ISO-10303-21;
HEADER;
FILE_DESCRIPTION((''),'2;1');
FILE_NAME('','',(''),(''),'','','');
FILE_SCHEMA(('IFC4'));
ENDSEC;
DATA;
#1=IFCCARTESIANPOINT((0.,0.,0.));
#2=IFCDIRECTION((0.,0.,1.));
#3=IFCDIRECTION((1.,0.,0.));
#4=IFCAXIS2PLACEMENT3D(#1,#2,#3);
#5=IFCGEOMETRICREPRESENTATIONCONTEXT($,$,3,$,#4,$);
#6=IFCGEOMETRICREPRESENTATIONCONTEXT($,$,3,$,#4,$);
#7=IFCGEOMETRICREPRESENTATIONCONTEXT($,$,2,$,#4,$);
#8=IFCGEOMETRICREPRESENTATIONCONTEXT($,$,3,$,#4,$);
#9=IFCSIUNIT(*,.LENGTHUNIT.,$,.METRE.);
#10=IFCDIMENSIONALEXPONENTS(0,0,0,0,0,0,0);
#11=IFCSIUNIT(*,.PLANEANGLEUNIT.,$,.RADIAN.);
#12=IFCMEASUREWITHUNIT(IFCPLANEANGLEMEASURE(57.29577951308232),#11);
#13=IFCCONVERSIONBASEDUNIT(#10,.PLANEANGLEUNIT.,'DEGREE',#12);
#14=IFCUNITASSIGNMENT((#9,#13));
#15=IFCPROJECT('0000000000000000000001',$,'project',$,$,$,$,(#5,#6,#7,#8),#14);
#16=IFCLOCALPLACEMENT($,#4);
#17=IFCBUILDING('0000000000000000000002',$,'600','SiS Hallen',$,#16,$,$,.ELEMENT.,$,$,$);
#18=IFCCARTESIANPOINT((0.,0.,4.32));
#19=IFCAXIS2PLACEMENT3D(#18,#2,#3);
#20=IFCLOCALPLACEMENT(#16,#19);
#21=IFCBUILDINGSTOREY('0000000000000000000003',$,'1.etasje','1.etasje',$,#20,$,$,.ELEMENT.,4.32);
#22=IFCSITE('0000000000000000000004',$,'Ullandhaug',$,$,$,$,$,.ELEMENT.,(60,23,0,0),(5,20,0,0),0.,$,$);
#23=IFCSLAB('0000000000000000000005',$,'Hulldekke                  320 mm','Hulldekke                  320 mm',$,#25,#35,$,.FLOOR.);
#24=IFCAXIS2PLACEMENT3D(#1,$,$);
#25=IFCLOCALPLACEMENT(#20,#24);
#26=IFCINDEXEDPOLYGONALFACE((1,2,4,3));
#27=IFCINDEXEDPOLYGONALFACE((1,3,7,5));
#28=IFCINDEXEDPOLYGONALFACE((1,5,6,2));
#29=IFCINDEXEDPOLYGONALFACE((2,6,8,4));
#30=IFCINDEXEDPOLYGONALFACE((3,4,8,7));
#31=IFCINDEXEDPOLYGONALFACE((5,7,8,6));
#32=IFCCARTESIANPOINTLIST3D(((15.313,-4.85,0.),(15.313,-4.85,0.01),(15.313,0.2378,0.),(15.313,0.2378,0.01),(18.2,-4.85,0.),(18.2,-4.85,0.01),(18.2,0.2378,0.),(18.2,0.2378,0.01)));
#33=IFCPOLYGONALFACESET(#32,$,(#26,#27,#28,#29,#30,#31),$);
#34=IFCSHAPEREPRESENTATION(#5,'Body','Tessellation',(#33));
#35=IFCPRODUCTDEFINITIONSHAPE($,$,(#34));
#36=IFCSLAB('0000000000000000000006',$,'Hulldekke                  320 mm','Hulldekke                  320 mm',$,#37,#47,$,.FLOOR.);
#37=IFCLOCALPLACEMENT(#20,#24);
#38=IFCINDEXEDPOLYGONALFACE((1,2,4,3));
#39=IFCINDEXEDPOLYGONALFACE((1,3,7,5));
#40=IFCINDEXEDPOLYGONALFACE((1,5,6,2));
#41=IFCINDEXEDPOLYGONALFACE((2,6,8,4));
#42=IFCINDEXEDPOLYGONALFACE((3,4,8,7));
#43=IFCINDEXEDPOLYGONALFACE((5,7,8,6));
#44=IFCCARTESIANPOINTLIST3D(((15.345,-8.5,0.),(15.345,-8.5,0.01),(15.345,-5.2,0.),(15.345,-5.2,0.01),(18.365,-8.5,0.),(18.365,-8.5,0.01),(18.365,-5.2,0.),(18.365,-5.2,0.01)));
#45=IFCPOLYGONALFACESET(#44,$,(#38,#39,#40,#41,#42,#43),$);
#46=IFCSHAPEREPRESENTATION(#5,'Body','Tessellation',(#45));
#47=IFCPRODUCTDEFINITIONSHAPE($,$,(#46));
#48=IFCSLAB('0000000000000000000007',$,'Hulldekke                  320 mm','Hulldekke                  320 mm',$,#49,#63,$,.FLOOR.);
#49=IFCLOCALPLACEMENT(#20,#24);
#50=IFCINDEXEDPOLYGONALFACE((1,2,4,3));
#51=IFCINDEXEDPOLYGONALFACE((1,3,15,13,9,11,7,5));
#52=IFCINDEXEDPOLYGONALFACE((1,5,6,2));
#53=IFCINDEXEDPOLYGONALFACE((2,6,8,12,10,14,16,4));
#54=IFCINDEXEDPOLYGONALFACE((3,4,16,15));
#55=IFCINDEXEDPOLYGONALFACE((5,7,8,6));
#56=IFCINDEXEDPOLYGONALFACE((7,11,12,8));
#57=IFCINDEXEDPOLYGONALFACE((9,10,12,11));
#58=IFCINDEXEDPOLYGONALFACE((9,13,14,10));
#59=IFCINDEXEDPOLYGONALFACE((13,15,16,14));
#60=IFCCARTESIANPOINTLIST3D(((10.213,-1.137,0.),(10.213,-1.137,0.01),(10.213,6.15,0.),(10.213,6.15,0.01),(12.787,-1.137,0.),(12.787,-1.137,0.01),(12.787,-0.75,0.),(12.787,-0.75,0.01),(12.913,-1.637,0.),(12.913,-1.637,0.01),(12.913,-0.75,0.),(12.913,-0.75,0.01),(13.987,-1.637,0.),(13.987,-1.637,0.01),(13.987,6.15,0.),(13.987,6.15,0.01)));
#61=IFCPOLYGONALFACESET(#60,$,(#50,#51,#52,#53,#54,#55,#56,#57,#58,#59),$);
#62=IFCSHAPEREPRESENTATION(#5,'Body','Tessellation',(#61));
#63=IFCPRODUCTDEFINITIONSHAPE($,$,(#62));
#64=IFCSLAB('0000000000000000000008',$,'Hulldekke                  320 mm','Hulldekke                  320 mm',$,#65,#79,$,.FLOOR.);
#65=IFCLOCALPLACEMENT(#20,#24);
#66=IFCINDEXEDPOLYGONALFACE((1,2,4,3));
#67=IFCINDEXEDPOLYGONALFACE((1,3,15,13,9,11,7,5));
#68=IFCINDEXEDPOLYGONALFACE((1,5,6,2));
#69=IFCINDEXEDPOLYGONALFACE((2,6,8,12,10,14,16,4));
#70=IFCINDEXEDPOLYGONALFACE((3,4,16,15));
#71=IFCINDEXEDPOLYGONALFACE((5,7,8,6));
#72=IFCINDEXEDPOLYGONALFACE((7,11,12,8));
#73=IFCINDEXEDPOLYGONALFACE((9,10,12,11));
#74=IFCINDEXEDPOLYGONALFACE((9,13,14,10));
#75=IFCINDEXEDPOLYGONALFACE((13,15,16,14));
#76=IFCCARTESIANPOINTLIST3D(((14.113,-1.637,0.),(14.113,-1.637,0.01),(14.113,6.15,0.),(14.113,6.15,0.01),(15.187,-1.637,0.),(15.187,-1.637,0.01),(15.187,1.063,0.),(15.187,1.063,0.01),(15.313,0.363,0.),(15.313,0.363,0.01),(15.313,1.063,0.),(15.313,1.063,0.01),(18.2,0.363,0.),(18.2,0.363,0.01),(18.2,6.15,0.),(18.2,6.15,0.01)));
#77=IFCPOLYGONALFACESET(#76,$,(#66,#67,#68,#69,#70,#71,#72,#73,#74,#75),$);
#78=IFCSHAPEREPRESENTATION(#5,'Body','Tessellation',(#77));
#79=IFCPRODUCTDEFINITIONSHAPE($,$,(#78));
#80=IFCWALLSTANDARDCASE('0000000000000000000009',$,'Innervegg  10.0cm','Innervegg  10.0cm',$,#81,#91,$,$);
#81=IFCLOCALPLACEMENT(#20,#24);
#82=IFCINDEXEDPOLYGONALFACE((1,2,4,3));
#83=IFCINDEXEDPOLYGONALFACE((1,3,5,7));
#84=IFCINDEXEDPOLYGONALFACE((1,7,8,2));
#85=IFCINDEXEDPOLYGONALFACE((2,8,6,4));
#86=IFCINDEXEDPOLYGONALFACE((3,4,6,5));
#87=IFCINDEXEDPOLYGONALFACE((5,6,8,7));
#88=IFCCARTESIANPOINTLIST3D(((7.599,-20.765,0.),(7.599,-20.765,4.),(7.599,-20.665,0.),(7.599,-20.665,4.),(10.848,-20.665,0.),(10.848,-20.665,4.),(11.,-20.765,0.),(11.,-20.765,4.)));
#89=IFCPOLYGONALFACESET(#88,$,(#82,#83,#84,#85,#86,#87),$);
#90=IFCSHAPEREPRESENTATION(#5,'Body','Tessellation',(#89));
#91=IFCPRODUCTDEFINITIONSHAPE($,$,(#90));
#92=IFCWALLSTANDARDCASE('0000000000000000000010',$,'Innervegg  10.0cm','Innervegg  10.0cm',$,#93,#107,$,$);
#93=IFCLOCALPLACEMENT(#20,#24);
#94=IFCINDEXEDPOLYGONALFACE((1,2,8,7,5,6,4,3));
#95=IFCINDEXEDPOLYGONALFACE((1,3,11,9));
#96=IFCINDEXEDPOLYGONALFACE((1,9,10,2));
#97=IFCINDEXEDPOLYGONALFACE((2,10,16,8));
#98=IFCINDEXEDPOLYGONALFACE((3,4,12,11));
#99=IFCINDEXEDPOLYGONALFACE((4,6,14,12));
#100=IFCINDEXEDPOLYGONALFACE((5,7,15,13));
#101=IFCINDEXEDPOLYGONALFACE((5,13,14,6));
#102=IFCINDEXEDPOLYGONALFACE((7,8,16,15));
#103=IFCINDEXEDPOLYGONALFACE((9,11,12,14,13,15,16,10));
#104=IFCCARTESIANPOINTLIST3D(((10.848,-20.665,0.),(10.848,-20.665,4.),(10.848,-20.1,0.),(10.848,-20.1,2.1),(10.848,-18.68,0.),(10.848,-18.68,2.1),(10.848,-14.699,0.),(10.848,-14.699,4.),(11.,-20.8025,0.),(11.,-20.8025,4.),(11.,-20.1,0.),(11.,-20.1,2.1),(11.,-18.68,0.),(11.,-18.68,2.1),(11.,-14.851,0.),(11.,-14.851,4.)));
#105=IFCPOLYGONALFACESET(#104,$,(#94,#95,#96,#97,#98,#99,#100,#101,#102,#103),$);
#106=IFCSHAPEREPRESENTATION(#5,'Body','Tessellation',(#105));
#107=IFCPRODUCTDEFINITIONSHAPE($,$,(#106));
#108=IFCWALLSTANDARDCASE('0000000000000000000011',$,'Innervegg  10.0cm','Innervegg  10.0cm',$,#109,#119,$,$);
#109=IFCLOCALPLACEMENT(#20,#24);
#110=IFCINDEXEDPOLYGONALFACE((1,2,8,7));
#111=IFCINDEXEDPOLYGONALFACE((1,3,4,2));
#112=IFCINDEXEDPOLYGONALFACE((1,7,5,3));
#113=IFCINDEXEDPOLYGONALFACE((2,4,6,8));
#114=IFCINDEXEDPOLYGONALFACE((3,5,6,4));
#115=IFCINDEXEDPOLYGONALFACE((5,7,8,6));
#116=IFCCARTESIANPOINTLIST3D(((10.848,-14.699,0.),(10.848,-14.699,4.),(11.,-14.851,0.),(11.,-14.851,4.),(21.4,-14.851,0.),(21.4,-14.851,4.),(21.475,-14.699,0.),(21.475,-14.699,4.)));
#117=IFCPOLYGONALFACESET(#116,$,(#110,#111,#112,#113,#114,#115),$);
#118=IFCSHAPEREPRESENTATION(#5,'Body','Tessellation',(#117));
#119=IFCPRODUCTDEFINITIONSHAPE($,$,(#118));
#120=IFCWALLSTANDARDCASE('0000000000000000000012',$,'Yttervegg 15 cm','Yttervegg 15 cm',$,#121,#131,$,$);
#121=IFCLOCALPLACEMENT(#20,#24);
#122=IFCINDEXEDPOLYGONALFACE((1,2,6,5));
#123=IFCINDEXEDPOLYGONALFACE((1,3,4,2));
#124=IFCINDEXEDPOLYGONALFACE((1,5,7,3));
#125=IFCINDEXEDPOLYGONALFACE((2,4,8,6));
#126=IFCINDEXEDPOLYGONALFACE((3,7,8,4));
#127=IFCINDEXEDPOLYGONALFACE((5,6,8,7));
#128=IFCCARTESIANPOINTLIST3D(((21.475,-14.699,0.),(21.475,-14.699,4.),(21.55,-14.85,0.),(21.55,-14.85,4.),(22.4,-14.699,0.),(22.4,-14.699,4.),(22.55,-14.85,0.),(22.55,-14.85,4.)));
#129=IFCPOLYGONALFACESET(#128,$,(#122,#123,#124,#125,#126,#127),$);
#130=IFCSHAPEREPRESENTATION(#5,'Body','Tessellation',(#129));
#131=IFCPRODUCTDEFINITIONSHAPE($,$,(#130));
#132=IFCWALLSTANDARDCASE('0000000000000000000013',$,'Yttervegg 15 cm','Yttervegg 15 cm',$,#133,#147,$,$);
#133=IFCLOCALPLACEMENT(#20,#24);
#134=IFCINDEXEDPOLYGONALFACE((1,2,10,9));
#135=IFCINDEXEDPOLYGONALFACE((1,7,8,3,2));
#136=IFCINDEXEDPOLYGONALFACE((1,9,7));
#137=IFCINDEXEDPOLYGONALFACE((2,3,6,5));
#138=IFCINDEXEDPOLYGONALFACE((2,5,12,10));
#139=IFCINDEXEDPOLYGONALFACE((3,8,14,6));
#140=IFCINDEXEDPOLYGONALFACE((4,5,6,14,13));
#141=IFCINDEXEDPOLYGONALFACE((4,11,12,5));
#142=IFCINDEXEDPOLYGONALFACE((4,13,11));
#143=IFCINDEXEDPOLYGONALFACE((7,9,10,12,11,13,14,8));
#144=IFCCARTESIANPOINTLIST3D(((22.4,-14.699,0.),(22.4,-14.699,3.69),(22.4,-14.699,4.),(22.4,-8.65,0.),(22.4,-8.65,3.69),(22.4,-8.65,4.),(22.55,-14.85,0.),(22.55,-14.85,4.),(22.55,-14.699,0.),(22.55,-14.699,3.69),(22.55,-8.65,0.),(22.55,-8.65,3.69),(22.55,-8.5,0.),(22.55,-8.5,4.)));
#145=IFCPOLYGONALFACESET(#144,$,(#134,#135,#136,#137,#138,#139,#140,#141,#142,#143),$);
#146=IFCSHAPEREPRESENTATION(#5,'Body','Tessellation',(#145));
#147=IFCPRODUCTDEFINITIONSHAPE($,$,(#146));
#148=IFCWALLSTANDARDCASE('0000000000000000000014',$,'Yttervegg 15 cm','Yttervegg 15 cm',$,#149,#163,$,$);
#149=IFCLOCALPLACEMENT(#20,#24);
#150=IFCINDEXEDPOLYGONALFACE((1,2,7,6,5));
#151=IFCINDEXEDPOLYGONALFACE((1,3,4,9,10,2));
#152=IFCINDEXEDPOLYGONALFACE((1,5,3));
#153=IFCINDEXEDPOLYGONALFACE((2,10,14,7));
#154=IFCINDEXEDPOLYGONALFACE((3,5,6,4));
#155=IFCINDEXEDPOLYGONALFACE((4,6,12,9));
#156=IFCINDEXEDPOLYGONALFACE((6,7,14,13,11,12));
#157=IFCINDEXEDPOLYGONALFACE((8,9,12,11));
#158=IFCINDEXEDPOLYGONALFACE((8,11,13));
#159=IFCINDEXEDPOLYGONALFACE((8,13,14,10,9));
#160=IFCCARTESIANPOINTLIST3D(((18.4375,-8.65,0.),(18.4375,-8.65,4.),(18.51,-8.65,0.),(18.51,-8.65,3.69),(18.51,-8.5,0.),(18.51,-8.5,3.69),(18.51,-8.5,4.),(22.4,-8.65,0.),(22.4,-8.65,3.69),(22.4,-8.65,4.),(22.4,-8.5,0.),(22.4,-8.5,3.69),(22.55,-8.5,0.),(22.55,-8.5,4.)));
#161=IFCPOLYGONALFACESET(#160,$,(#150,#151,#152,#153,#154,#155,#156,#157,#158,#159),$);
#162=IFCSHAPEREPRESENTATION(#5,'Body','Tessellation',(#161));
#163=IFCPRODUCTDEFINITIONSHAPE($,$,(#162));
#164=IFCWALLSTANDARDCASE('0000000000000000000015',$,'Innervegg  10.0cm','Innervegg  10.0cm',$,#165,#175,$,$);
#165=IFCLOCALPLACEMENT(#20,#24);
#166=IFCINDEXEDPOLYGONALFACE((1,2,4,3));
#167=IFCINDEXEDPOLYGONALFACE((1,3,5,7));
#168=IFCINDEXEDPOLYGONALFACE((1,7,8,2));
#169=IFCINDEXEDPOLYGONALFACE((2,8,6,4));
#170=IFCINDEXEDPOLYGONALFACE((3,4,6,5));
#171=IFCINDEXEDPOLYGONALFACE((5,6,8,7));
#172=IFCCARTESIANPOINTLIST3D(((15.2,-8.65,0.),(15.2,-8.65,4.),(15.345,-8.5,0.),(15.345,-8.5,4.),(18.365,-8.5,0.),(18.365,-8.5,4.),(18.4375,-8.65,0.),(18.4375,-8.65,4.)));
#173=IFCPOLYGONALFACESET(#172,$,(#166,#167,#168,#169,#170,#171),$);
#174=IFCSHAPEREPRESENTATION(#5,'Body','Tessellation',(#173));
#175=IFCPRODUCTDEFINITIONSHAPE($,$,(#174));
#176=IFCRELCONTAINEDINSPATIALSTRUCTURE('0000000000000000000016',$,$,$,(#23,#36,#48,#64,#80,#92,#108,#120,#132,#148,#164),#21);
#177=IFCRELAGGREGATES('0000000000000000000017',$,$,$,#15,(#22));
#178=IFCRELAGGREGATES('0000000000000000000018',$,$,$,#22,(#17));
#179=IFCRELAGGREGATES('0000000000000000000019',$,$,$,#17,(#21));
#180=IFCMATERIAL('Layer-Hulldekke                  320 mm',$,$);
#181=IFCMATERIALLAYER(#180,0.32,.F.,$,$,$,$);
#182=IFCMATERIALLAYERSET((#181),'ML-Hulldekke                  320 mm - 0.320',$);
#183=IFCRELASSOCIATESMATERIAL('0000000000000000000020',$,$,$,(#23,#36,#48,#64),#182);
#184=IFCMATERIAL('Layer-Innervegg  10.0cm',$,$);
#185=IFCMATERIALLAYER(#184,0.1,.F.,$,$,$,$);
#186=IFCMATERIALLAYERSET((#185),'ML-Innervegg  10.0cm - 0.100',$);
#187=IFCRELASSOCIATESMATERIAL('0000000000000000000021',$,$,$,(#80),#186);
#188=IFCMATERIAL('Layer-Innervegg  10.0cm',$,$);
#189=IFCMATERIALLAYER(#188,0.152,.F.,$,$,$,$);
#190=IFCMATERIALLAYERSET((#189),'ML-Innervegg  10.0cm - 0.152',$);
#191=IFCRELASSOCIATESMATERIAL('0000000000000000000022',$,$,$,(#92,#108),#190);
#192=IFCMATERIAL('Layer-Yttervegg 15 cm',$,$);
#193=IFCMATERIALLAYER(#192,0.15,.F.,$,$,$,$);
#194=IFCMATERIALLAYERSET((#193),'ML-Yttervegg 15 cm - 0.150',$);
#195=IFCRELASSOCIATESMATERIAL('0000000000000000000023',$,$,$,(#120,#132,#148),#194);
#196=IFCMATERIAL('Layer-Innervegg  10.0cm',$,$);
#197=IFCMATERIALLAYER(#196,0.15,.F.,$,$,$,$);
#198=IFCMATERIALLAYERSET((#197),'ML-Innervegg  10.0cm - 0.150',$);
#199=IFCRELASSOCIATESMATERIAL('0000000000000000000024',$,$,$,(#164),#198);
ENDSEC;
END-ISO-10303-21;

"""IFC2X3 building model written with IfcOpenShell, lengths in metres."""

from ifc_helpers import new_model, entity, si_unit, converted_unit, frame, origin_with_axes, place, context, project, spatial, polyline, outline, extrude, material, layer, layer_set, layer_usage, element, save


model = new_model("IFC2X3")

# Units and contexts
context_of_model_1 = context(None, 3, world=origin_with_axes())
context_of_model_2 = context(None, 3, world=origin_with_axes())
context_of_model_3 = context(None, 2, world=origin_with_axes())
context_of_model_4 = context(None, 3, world=origin_with_axes())
ifc_project = project(units=[si_unit("LENGTHUNIT", "METRE"), converted_unit("PLANEANGLEUNIT", "DEGREE", entity("IfcPlaneAngleMeasure", 57.29577951308232), si_unit("PLANEANGLEUNIT", "RADIAN"), dimensions=[0, 0, 0, 0, 0, 0, 0])], contexts=[context_of_model_1, context_of_model_2, context_of_model_3, context_of_model_4])

# Site, building, storey
site = spatial("IfcSite", under=ifc_project, Name="Ullandhaug", CompositionType="ELEMENT", RefLatitude=(60, 23, 0, 0), RefLongitude=(5, 20, 0, 0), RefElevation=0.0)
building_placement = place(None, origin_with_axes())
building = spatial("IfcBuilding", under=site, at=building_placement, Name="600", Description="SiS Hallen", CompositionType="ELEMENT")
storey_placement = place(building_placement, frame((0.0, 0.0, 4.32), z_axis=(0.0, 0.0, 1.0), x_axis=(1.0, 0.0, 0.0)))
storey = spatial("IfcBuildingStorey", under=building, at=storey_placement, Name="1.etasje", Description="1.etasje", CompositionType="ELEMENT", Elevation=4.32)

# Slabs
ifc_material_1 = material(Name="Layer-Hulldekke                  320 mm")
ifc_layer_1 = layer(ifc_material_1, 0.32, ventilated=False)
ifc_layer_set_1 = layer_set([ifc_layer_1], Name="ML-Hulldekke                  320 mm - 0.320")
ifc_layer_usage_1 = layer_usage(ifc_layer_set_1, "AXIS2", "POSITIVE", 0.0)
slab_1_placement = place(storey_placement, frame((15.313, -4.85, 0.0), z_axis=(0.0, 0.0, 1.0), x_axis=(1.0, 0.0, 0.0)))
element("IfcSlab", 1, at=slab_1_placement, inside=storey, material=ifc_layer_usage_1, Name="Hulldekke                  320 mm", Description="Hulldekke                  320 mm", PredefinedType="FLOOR", context=context_of_model_1, shape_type="SweptSolid", body=[
    extrude(outline(polyline([(0.0, 0.0), (2.887, 0.0), (2.887, 5.0878), (0.0, 5.0878), (0.0, 0.0)])), origin_with_axes(), (0.0, 0.0, 1.0), 0.01),
])
slab_2_placement = place(storey_placement, frame((15.345, -8.5, 0.0), z_axis=(0.0, 0.0, 1.0), x_axis=(1.0, 0.0, 0.0)))
element("IfcSlab", 2, at=slab_2_placement, inside=storey, material=ifc_layer_usage_1, Name="Hulldekke                  320 mm", Description="Hulldekke                  320 mm", PredefinedType="FLOOR", context=context_of_model_1, shape_type="SweptSolid", body=[
    extrude(outline(polyline([(0.0, 0.0), (3.02, 0.0), (3.02, 3.3), (0.0, 3.3), (0.0, 0.0)])), origin_with_axes(), (0.0, 0.0, 1.0), 0.01),
])
slab_3_placement = place(storey_placement, frame((12.913, -1.637, 0.0), z_axis=(0.0, 0.0, 1.0), x_axis=(1.0, 0.0, 0.0)))
element("IfcSlab", 3, at=slab_3_placement, inside=storey, material=ifc_layer_usage_1, Name="Hulldekke                  320 mm", Description="Hulldekke                  320 mm", PredefinedType="FLOOR", context=context_of_model_1, shape_type="SweptSolid", body=[
    extrude(outline(polyline([(0.0, 0.0), (1.074, 0.0), (1.074, 7.787), (-2.7, 7.787), (-2.7, 0.5), (-0.126, 0.5), (-0.126, 0.887), (0.0, 0.887), (0.0, 0.0)])), origin_with_axes(), (0.0, 0.0, 1.0), 0.01),
])
slab_4_placement = place(storey_placement, frame((14.113, -1.637, 0.0), z_axis=(0.0, 0.0, 1.0), x_axis=(1.0, 0.0, 0.0)))
element("IfcSlab", 4, at=slab_4_placement, inside=storey, material=ifc_layer_usage_1, Name="Hulldekke                  320 mm", Description="Hulldekke                  320 mm", PredefinedType="FLOOR", context=context_of_model_1, shape_type="SweptSolid", body=[
    extrude(outline(polyline([(0.0, 0.0), (1.074, 0.0), (1.074, 2.7), (1.2, 2.7), (1.2, 2.0), (4.087, 2.0), (4.087, 7.787), (0.0, 7.787), (0.0, 0.0)])), origin_with_axes(), (0.0, 0.0, 1.0), 0.01),
])

# Wall
ifc_material_2 = material(Name="Layer-Yttervegg 15 cm")
ifc_layer_2 = layer(ifc_material_2, 0.15, ventilated=False)
ifc_layer_set_2 = layer_set([ifc_layer_2], Name="ML-Yttervegg 15 cm - 0.150")
ifc_layer_usage_2 = layer_usage(ifc_layer_set_2, "AXIS2", "POSITIVE", 0.0)
ifc_material_3 = material(Name="Layer-Innervegg  10.0cm")
ifc_layer_3 = layer(ifc_material_3, 0.1, ventilated=False)
ifc_layer_set_3 = layer_set([ifc_layer_3], Name="ML-Innervegg  10.0cm - 0.100")
ifc_layer_usage_3 = layer_usage(ifc_layer_set_3, "AXIS2", "POSITIVE", 0.0)
wall_1_placement = place(storey_placement, frame((7.599, -20.765, 0.0), z_axis=(0.0, 0.0, 1.0), x_axis=(1.0, 0.0, 0.0)))
element("IfcWallStandardCase", 5, at=wall_1_placement, inside=storey, material=ifc_layer_usage_3, Name="Innervegg  10.0cm", Description="Innervegg  10.0cm", context=context_of_model_1, shape_type="SweptSolid", body=[
    extrude(outline(polyline([(0.0, 0.0), (3.401, 0.0), (3.249, 0.1), (0.0, 0.1), (0.0, 0.0)])), origin_with_axes(), (0.0, 0.0, 1.0), 4.0),
])

# Wall, opening
ifc_material_4 = material(Name="Layer-Innervegg  10.0cm")
ifc_layer_4 = layer(ifc_material_4, 0.152, ventilated=False)
ifc_layer_set_4 = layer_set([ifc_layer_4], Name="ML-Innervegg  10.0cm - 0.152")
ifc_layer_usage_4 = layer_usage(ifc_layer_set_4, "AXIS2", "POSITIVE", 0.0)
wall_2_placement = place(storey_placement, frame((11.0, -20.8025, 0.0), z_axis=(0.0, 0.0, 1.0), x_axis=(0.0, 1.0, 0.0)))
wall_2 = element("IfcWallStandardCase", 6, at=wall_2_placement, inside=storey, material=ifc_layer_usage_4, Name="Innervegg  10.0cm", Description="Innervegg  10.0cm", context=context_of_model_1, shape_type="SweptSolid", body=[
    extrude(outline(polyline([(0.0, 0.0), (5.9515, 0.0), (6.1035, 0.152), (0.1375, 0.152), (0.0, 0.0)])), frame((0.0, 0.0, 0.0), z_axis=(0.0, 0.0, 1.0), x_axis=(1.0, 0.0, 0.0)), (0.0, 0.0, 1.0), 4.0),
])
opening_1_placement = place(wall_2_placement, frame((0.7025, 0.152, 0.0), z_axis=(0.0, 0.0, 1.0), x_axis=(1.0, 0.0, 0.0)))
element("IfcOpeningElement", 7, at=opening_1_placement, cuts=wall_2, context=context_of_model_1, shape_type="SweptSolid", body=[
    extrude(outline(polyline([(0.0, 0.0), (2.1, 0.0), (2.1, 1.42), (0.0, 1.42), (0.0, 0.0)])), frame((0.0, 0.0, 0.0), z_axis=(0.0, 1.0, 0.0), x_axis=(0.0, 0.0, 1.0)), (0.0, 0.0, -1.0), 0.152),
])

# Walls
wall_3_placement = place(storey_placement, frame((11.0, -14.851, 0.0), z_axis=(0.0, 0.0, 1.0), x_axis=(1.0, 0.0, 0.0)))
element("IfcWallStandardCase", 8, at=wall_3_placement, inside=storey, material=ifc_layer_usage_4, Name="Innervegg  10.0cm", Description="Innervegg  10.0cm", context=context_of_model_1, shape_type="SweptSolid", body=[
    extrude(outline(polyline([(0.0, 0.0), (10.4, 0.0), (10.475, 0.152), (-0.152, 0.152), (0.0, 0.0)])), origin_with_axes(), (0.0, 0.0, 1.0), 4.0),
])
wall_4_placement = place(storey_placement, frame((21.55, -14.85, 0.0), z_axis=(0.0, 0.0, 1.0), x_axis=(1.0, 0.0, 0.0)))
element("IfcWallStandardCase", 9, at=wall_4_placement, inside=storey, material=ifc_layer_usage_2, Name="Yttervegg 15 cm", Description="Yttervegg 15 cm", context=context_of_model_1, shape_type="SweptSolid", body=[
    extrude(outline(polyline([(0.0, 0.0), (1.0, 0.0), (0.85, 0.151), (-0.075, 0.151), (0.0, 0.0)])), origin_with_axes(), (0.0, 0.0, 1.0), 4.0),
])

# Walls, openings
wall_5_placement = place(storey_placement, frame((22.55, -14.85, 0.0), z_axis=(0.0, 0.0, 1.0), x_axis=(0.0, 1.0, 0.0)))
wall_5 = element("IfcWallStandardCase", 10, at=wall_5_placement, inside=storey, material=ifc_layer_usage_2, Name="Yttervegg 15 cm", Description="Yttervegg 15 cm", context=context_of_model_1, shape_type="SweptSolid", body=[
    extrude(outline(polyline([(0.0, 0.0), (6.35, 0.0), (6.2, 0.15), (0.151, 0.15), (0.0, 0.0)])), frame((0.0, 0.0, 0.0), z_axis=(0.0, 0.0, 1.0), x_axis=(1.0, 0.0, 0.0)), (0.0, 0.0, 1.0), 4.0),
])
opening_2_placement = place(wall_5_placement, frame((0.151, 0.15, 0.0), z_axis=(0.0, 0.0, 1.0), x_axis=(1.0, 0.0, 0.0)))
element("IfcOpeningElement", 11, at=opening_2_placement, cuts=wall_5, context=context_of_model_1, shape_type="SweptSolid", body=[
    extrude(outline(polyline([(0.0, 0.0), (3.69, 0.0), (3.69, 6.049), (0.0, 6.049), (0.0, 0.0)])), frame((0.0, 0.0, 0.0), z_axis=(0.0, 1.0, 0.0), x_axis=(0.0, 0.0, 1.0)), (0.0, 0.0, -1.0), 0.15),
])
wall_6_placement = place(storey_placement, frame((22.55, -8.5, 0.0), z_axis=(0.0, 0.0, 1.0), x_axis=(-1.0, 0.0, 0.0)))
wall_6 = element("IfcWallStandardCase", 12, at=wall_6_placement, inside=storey, material=ifc_layer_usage_2, Name="Yttervegg 15 cm", Description="Yttervegg 15 cm", context=context_of_model_1, shape_type="SweptSolid", body=[
    extrude(outline(polyline([(0.0, 0.0), (4.04, 0.0), (4.1125, 0.15), (0.15, 0.15), (0.0, 0.0)])), frame((0.0, 0.0, 0.0), z_axis=(0.0, 0.0, 1.0), x_axis=(1.0, 0.0, 0.0)), (0.0, 0.0, 1.0), 4.0),
])
opening_3_placement = place(wall_6_placement, frame((0.15, 0.15, 0.0), z_axis=(0.0, 0.0, 1.0), x_axis=(1.0, 0.0, 0.0)))
element("IfcOpeningElement", 13, at=opening_3_placement, cuts=wall_6, context=context_of_model_1, shape_type="SweptSolid", body=[
    extrude(outline(polyline([(0.0, 0.0), (3.69, 0.0), (3.69, 3.89), (0.0, 3.89), (0.0, 0.0)])), frame((0.0, 0.0, 0.0), z_axis=(0.0, 1.0, 0.0), x_axis=(0.0, 0.0, 1.0)), (0.0, 0.0, -1.0), 0.15),
])

# Wall
ifc_material_5 = material(Name="Layer-Innervegg  10.0cm")
ifc_layer_5 = layer(ifc_material_5, 0.15, ventilated=False)
ifc_layer_set_5 = layer_set([ifc_layer_5], Name="ML-Innervegg  10.0cm - 0.150")
ifc_layer_usage_5 = layer_usage(ifc_layer_set_5, "AXIS2", "POSITIVE", 0.0)
wall_7_placement = place(storey_placement, frame((18.365, -8.5, 0.0), z_axis=(0.0, 0.0, 1.0), x_axis=(-1.0, 0.0, 0.0)))
element("IfcWallStandardCase", 14, at=wall_7_placement, inside=storey, material=ifc_layer_usage_5, Name="Innervegg  10.0cm", Description="Innervegg  10.0cm", context=context_of_model_1, shape_type="SweptSolid", body=[
    extrude(outline(polyline([(0.0, 0.0), (3.02, 0.0), (3.165, 0.15), (-0.0725, 0.15), (0.0, 0.0)])), frame((0.0, 0.0, 0.0), z_axis=(0.0, 0.0, 1.0), x_axis=(1.0, 0.0, 0.0)), (0.0, 0.0, 1.0), 4.0),
])

save(model, "model.ifc")
